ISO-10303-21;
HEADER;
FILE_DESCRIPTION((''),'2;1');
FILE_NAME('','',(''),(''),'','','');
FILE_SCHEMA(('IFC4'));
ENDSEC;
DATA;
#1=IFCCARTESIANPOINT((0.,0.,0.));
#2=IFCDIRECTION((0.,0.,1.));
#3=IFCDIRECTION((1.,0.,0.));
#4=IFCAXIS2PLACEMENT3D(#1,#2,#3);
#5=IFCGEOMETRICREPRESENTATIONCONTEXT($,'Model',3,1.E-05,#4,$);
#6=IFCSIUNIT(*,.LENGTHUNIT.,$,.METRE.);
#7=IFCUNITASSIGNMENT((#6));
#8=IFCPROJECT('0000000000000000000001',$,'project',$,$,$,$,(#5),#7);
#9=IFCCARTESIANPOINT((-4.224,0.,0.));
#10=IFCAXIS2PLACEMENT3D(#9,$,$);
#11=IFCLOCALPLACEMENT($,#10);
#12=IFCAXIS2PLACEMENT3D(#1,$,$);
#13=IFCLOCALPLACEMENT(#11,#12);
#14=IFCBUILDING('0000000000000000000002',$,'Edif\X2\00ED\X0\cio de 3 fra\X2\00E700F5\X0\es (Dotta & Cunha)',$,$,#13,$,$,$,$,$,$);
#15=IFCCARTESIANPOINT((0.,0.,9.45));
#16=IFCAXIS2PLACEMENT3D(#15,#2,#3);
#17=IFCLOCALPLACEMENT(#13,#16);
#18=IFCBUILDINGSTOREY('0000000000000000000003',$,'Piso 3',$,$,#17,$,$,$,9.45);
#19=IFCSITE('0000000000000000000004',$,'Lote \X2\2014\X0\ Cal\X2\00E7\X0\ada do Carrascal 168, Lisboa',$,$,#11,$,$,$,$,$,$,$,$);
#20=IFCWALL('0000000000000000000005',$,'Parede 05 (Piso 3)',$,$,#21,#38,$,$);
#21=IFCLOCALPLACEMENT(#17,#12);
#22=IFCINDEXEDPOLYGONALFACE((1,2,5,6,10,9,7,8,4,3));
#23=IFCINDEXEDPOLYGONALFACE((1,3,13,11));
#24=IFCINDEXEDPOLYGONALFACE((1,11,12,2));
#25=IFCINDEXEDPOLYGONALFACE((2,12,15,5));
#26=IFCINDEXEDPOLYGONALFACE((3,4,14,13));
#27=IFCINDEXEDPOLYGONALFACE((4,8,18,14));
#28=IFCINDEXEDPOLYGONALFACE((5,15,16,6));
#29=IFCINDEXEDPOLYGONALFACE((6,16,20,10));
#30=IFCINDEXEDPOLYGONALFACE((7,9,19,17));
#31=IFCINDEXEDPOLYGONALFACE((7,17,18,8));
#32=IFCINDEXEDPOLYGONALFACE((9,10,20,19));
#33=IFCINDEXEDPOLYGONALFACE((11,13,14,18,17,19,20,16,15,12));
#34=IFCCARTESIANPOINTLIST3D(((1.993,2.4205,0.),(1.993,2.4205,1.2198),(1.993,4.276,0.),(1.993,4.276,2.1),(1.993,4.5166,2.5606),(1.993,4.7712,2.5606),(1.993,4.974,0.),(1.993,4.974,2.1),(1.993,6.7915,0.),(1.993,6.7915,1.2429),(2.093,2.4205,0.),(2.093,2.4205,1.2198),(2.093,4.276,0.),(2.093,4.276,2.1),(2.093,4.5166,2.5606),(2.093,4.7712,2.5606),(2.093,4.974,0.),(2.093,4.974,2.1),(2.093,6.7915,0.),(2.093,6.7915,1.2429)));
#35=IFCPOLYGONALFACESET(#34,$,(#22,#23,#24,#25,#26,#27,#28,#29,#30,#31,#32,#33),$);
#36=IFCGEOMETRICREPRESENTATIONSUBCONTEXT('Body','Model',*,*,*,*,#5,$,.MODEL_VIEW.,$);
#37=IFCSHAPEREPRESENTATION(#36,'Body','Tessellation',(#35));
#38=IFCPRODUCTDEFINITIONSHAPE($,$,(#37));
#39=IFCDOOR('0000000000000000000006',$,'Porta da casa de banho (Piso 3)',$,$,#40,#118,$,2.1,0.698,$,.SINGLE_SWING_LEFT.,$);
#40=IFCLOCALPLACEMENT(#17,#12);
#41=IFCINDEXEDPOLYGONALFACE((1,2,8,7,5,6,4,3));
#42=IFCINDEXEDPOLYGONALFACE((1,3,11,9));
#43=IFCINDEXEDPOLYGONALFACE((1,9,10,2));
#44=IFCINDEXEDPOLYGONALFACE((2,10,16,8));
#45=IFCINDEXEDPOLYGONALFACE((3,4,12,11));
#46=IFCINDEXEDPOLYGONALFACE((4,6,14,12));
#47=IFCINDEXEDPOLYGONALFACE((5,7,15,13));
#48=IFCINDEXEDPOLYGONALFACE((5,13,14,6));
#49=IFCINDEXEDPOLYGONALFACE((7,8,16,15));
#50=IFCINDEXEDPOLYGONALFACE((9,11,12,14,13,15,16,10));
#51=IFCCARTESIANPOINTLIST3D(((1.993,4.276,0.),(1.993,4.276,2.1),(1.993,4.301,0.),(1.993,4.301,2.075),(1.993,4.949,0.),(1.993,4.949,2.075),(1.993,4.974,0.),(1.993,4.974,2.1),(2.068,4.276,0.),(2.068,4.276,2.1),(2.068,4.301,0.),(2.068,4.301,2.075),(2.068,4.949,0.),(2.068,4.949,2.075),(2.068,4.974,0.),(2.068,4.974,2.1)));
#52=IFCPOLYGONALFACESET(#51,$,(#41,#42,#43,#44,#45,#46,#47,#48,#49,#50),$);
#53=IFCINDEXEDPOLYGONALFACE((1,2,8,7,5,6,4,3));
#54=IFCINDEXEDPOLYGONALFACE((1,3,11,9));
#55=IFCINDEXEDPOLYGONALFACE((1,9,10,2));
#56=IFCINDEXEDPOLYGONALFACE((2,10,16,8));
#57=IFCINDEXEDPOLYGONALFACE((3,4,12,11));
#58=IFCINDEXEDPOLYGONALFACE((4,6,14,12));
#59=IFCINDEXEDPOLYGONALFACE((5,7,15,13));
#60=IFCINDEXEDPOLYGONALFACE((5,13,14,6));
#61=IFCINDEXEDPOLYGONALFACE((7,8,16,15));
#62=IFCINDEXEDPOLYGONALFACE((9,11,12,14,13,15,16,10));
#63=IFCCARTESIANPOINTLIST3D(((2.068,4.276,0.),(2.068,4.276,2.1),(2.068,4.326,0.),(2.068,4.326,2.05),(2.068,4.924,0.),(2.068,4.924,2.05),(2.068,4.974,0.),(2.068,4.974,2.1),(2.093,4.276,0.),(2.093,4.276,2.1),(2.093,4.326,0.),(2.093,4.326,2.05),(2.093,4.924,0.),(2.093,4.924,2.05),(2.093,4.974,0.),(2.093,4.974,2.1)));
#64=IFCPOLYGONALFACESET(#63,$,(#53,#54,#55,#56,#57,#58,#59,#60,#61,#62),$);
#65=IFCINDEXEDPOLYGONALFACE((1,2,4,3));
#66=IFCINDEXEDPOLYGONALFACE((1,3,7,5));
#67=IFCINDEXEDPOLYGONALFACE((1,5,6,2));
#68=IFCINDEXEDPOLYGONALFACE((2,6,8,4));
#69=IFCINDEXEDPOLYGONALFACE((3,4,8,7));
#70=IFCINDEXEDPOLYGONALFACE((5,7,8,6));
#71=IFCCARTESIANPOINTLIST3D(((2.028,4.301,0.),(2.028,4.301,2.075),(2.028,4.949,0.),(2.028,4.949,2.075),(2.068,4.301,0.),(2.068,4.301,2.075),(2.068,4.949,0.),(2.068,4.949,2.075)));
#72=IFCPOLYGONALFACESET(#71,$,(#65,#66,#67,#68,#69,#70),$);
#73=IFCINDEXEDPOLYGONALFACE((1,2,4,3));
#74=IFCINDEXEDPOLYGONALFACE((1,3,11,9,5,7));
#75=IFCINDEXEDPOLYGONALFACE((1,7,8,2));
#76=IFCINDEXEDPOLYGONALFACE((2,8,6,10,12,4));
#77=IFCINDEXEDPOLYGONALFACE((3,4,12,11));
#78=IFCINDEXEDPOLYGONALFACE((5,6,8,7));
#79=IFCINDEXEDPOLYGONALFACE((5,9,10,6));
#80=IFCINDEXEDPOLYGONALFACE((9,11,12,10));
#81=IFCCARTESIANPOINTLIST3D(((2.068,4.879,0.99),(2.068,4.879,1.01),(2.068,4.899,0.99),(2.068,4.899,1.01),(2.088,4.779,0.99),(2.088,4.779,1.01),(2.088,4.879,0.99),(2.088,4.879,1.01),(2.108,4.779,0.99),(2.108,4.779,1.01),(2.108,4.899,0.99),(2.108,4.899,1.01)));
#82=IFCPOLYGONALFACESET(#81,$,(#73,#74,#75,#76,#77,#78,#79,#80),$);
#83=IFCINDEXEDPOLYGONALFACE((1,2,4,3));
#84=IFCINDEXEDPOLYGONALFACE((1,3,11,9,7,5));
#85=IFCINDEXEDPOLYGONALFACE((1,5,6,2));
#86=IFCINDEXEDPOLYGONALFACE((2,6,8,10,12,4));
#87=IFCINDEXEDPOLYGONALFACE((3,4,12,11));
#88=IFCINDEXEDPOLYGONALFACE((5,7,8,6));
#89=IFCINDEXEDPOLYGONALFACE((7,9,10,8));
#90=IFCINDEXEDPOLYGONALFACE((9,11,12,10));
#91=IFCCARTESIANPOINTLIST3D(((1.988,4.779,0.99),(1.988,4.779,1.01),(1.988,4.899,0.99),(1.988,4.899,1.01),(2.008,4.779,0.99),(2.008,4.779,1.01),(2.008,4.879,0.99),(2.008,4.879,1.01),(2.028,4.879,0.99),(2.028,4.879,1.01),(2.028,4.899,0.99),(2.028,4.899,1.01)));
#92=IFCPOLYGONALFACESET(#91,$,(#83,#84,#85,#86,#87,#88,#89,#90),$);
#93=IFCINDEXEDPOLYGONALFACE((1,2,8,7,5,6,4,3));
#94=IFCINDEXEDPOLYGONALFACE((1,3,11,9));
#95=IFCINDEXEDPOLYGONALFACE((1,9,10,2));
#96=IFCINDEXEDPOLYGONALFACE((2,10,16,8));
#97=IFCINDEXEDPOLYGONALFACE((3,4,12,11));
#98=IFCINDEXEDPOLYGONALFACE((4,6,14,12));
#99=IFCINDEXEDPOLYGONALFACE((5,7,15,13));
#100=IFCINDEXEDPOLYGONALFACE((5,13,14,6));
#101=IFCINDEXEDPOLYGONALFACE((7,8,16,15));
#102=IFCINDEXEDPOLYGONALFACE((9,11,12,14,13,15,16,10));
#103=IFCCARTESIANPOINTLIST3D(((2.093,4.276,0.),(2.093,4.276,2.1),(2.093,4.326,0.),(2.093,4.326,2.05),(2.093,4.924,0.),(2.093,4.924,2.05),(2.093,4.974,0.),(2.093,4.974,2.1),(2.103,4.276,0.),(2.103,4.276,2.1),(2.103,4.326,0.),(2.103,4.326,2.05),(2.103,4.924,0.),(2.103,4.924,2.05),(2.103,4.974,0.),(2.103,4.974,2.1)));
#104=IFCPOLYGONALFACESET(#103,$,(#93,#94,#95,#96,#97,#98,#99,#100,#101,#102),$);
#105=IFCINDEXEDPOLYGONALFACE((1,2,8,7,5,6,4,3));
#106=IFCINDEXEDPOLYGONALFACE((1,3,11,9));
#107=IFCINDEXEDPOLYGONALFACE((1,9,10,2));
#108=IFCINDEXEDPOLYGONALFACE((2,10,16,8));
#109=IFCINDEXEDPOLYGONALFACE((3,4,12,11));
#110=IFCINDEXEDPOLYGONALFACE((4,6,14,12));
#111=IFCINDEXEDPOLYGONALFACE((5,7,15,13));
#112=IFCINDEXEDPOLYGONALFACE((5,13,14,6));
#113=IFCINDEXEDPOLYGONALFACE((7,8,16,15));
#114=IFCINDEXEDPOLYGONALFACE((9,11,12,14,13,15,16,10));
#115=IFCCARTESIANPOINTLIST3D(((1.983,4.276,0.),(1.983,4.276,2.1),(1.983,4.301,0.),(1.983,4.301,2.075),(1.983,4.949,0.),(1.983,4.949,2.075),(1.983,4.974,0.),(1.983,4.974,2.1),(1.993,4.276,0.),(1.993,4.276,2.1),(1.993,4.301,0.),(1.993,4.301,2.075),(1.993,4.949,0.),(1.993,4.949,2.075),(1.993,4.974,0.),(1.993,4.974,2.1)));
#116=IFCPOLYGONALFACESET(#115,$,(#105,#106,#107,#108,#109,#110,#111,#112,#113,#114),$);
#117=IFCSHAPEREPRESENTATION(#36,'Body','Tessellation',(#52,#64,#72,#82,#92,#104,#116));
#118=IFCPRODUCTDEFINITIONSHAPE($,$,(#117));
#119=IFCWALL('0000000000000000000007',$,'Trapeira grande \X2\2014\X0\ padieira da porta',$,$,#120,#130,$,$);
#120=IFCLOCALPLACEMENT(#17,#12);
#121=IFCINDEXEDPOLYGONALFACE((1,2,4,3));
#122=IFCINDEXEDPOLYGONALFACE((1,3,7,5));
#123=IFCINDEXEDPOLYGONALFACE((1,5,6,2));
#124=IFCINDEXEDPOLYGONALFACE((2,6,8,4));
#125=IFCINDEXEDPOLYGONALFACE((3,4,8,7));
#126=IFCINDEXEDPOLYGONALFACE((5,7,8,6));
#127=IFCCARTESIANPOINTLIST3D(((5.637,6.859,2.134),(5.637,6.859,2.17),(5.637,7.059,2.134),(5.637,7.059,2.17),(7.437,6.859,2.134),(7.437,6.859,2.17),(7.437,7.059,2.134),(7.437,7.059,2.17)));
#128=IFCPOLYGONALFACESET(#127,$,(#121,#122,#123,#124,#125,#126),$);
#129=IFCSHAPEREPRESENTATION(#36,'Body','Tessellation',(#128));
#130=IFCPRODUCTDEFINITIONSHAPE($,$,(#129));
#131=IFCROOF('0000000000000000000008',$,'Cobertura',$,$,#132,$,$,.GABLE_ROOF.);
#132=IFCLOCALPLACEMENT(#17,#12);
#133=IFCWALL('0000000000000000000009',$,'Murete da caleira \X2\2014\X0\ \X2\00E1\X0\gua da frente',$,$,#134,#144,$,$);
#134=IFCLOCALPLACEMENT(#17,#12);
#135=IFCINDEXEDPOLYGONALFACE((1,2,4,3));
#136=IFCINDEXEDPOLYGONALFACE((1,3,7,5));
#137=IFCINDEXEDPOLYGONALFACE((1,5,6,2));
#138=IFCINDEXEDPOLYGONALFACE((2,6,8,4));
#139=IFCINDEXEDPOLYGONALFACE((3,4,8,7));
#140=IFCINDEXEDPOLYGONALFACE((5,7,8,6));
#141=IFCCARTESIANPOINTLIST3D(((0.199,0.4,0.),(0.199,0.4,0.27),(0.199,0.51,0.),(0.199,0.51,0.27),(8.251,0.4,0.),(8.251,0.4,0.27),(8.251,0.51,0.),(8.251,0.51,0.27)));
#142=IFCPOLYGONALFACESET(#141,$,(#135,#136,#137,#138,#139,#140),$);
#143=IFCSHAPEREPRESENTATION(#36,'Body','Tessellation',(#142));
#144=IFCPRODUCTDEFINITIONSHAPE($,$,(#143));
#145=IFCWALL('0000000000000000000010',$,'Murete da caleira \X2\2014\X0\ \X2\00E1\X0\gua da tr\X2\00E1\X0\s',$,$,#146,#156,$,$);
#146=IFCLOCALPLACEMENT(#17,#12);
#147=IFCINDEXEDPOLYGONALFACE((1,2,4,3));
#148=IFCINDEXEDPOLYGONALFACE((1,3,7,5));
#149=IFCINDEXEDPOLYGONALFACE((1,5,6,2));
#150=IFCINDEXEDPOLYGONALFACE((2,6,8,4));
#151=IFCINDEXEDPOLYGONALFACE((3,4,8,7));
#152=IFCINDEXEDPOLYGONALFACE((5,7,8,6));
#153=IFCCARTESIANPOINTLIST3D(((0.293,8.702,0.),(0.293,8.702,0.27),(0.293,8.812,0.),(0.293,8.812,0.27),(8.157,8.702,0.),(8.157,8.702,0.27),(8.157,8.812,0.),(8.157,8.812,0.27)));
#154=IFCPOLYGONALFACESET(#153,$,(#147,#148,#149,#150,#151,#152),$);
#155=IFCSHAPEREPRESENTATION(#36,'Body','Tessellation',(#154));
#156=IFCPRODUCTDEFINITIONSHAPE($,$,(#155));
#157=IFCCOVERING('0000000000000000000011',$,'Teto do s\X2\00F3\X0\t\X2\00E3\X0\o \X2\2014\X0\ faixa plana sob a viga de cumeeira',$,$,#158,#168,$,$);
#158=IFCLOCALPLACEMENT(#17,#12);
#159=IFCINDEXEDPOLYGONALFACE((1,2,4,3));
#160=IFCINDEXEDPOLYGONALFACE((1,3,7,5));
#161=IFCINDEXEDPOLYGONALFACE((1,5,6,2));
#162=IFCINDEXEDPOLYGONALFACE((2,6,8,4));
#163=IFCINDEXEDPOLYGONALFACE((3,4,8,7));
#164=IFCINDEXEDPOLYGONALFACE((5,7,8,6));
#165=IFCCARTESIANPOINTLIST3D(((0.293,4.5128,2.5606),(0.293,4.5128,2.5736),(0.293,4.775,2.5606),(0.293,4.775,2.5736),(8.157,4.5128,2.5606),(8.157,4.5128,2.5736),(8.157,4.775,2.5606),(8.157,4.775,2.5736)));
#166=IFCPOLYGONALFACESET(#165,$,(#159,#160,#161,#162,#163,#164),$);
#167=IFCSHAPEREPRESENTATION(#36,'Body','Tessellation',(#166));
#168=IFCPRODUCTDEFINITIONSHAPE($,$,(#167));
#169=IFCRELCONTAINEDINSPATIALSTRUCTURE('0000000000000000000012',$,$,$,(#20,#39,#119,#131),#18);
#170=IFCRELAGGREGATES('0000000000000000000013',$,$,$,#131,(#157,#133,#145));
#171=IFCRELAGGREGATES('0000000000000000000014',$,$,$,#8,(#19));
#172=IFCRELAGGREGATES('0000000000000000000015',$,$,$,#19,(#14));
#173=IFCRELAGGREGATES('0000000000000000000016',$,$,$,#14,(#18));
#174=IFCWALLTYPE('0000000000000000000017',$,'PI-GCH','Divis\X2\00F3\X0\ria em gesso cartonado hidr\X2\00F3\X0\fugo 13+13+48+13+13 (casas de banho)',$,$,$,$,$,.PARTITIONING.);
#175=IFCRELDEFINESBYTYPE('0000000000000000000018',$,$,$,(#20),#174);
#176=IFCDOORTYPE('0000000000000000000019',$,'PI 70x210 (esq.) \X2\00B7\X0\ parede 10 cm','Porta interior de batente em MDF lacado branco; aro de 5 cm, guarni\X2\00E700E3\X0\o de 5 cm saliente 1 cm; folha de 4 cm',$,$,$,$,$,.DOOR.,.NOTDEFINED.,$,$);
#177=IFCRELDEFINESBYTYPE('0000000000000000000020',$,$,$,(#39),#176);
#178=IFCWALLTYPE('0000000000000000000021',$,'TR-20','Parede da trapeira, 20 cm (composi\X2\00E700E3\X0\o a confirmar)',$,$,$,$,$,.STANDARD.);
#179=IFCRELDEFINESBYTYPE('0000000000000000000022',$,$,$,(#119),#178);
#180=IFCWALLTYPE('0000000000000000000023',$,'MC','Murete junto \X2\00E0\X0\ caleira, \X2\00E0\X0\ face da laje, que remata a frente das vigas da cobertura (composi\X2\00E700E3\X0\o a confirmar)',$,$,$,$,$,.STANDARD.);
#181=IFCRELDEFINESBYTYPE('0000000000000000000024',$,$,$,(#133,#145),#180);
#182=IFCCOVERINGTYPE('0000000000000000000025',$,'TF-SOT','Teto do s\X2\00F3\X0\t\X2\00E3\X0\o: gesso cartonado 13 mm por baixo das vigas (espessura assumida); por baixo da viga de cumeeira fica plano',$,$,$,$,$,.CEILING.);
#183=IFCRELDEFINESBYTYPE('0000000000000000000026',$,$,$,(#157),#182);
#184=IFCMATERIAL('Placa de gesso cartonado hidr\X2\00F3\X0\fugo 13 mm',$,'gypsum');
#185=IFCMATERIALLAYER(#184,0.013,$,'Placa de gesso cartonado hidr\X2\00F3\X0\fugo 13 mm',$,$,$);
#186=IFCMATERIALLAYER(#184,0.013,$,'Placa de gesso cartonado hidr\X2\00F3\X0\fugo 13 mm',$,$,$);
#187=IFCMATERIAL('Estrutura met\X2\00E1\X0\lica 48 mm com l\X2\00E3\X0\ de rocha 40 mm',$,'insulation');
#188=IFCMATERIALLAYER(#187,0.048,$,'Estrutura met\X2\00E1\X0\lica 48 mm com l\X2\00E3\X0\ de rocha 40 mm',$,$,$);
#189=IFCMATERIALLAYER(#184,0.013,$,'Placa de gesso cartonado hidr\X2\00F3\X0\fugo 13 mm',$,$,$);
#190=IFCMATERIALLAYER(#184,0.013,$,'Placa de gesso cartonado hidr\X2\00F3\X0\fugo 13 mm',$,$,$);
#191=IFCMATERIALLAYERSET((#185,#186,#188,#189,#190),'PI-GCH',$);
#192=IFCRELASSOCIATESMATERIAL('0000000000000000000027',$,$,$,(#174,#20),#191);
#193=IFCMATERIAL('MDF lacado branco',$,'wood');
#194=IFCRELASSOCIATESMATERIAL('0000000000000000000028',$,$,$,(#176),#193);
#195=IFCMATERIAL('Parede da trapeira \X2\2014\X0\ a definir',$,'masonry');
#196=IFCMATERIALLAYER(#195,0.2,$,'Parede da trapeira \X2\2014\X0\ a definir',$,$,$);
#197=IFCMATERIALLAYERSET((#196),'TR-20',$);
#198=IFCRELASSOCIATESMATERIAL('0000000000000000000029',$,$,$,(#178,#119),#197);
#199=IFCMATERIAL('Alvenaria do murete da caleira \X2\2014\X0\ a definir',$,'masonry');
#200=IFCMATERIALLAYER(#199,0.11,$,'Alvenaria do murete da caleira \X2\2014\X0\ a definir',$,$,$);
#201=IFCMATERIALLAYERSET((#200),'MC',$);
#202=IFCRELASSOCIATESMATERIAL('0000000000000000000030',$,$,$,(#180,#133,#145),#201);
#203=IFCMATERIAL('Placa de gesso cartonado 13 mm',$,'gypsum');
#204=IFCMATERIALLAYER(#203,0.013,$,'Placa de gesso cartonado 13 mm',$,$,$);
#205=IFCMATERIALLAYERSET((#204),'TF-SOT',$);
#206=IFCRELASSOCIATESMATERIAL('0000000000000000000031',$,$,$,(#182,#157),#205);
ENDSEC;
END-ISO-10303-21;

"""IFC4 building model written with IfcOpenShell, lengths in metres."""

from ifc_helpers import new_model, si_unit, frame, origin, origin_with_axes, place, context, subcontext, project, spatial, line, indexed_curve, outline, extrude, clip, halfspace, source, transform, mapped, material, layer, layer_set, layer_usage, type_object, type_shapes, element, fill, aggregate, save


model = new_model("IFC4")

# Units and contexts
model_context = context("Model", 3, precision=1e-05, world=origin_with_axes())
body_context = subcontext(model_context, "Body", "Model", "MODEL_VIEW")
ifc_project = project(units=[si_unit("LENGTHUNIT", "METRE")], contexts=[model_context])

# Site, building, storey
site_placement = place(None, frame((-4.224, 0.0, 0.0)))
site = spatial("IfcSite", under=ifc_project, at=site_placement, Name="Lote — Calçada do Carrascal 168, Lisboa")
building_placement = place(site_placement, origin())
building = spatial("IfcBuilding", under=site, at=building_placement, Name="Edifício de 3 frações (Dotta & Cunha)")
storey_placement = place(building_placement, frame((0.0, 0.0, 9.45), z_axis=(0.0, 0.0, 1.0), x_axis=(1.0, 0.0, 0.0)))
storey = spatial("IfcBuildingStorey", under=building, at=storey_placement, Name="Piso 3", Elevation=9.45)

# Wall, opening, door
ifc_material_1 = material(Name="Placa de gesso cartonado 13 mm", Category="gypsum")
ifc_material_2 = material(Name="Estrutura metálica 48 mm com lã de rocha 40 mm", Category="insulation")
ifc_material_3 = material(Name="MDF lacado branco", Category="wood")
ifc_material_4 = material(Name="Placa de gesso cartonado hidrófugo 13 mm", Category="gypsum")
ifc_layer_1 = layer(ifc_material_4, 0.013, Name="Placa de gesso cartonado hidrófugo 13 mm")
ifc_layer_2 = layer(ifc_material_4, 0.013, Name="Placa de gesso cartonado hidrófugo 13 mm")
ifc_layer_3 = layer(ifc_material_2, 0.048, Name="Estrutura metálica 48 mm com lã de rocha 40 mm")
ifc_layer_4 = layer(ifc_material_4, 0.013, Name="Placa de gesso cartonado hidrófugo 13 mm")
ifc_layer_5 = layer(ifc_material_4, 0.013, Name="Placa de gesso cartonado hidrófugo 13 mm")
ifc_layer_set_1 = layer_set([ifc_layer_1, ifc_layer_2, ifc_layer_3, ifc_layer_4, ifc_layer_5], Name="PI-GCH")
ifc_layer_usage_1 = layer_usage(ifc_layer_set_1, "AXIS2", "POSITIVE", 0.0)
wall_type_1 = type_object("IfcWallType", Name="PI-GCH", Description="Divisória em gesso cartonado hidrófugo 13+13+48+13+13 (casas de banho)", PredefinedType="PARTITIONING", material=ifc_layer_set_1)
wall_1_placement = place(storey_placement, origin_with_axes())
wall_1 = element("IfcWall", 1, at=wall_1_placement, inside=storey, type_object=wall_type_1, material=ifc_layer_usage_1, Name="Parede 05 (Piso 3)", context=body_context, shape_type="Clipping", body=[
    clip(clip(extrude(outline(indexed_curve([(2.093, 2.4205), (2.093, 6.7915), (1.993, 6.7915), (1.993, 2.4205)], segments=[line(1, 2, 3, 4, 1)])), origin_with_axes(), (0.0, 0.0, 1.0), 2.5606), halfspace(frame((0.0, -4.1406, -2.9773), z_axis=(0.0, -0.538875, 0.842386), x_axis=(1.0, 0.0, 0.0)), False)), halfspace(frame((0.0, 6.9196, 1.1594), z_axis=(0.0, 0.546292, 0.837595), x_axis=(1.0, 0.0, 0.0)), False)),
])
opening_1_placement = place(wall_1_placement, origin_with_axes())
opening_1 = element("IfcOpeningElement", 2, at=opening_1_placement, cuts=wall_1, context=body_context, shape_type="SweptSolid", body=[
    extrude(outline(indexed_curve([(2.095, 4.276), (2.095, 4.974), (1.991, 4.974), (1.991, 4.276)], segments=[line(1, 2, 3, 4, 1)])), origin_with_axes(), (0.0, 0.0, 1.0), 2.1),
])
door_type_1 = type_object("IfcDoorType", Name="PI 70x210 (esq.) · parede 10 cm", Description="Porta interior de batente em MDF lacado branco; aro de 5 cm, guarnição de 5 cm saliente 1 cm; folha de 4 cm", OperationType="NOTDEFINED", PredefinedType="DOOR", material=ifc_material_3)
shared_shape_1 = source(origin_with_axes(), body_context, "Body", "SweptSolid", [
    extrude(outline(indexed_curve([(0.0, 0.0), (0.0, 2.1), (0.698, 2.1), (0.698, 0.0), (0.673, 0.0), (0.673, 2.075), (0.025, 2.075), (0.025, 0.0)], segments=[line(1, 2, 3, 4, 5, 6, 7, 8, 1)])), frame((0.0, 0.025, 0.0), z_axis=(0.0, -1.0, 0.0), x_axis=(1.0, 0.0, 0.0)), (0.0, 0.0, -1.0), 0.075),
    extrude(outline(indexed_curve([(0.0, 0.0), (0.0, 2.1), (0.698, 2.1), (0.698, 0.0), (0.648, 0.0), (0.648, 2.05), (0.05, 2.05), (0.05, 0.0)], segments=[line(1, 2, 3, 4, 5, 6, 7, 8, 1)])), frame((0.0, 0.0, 0.0), z_axis=(0.0, -1.0, 0.0), x_axis=(1.0, 0.0, 0.0)), (0.0, 0.0, -1.0), 0.025),
    extrude(outline(indexed_curve([(0.0, 0.0), (0.648, 0.0), (0.648, 0.04), (0.0, 0.04)], segments=[line(1, 2, 3, 4, 1)])), frame((0.025, 0.025, 0.0), z_axis=(0.0, 0.0, 1.0), x_axis=(1.0, 0.0, 0.0)), (0.0, 0.0, 1.0), 2.075),
    extrude(outline(indexed_curve([(0.0, 0.0), (0.0, -0.04), (-0.12, -0.04), (-0.12, -0.02), (-0.02, -0.02), (-0.02, 0.0)], segments=[line(1, 2, 3, 4, 5, 6, 1)])), frame((0.623, 0.025, 0.99), z_axis=(0.0, 0.0, 1.0), x_axis=(1.0, 0.0, 0.0)), (0.0, 0.0, 1.0), 0.02),
    extrude(outline(indexed_curve([(0.0, 0.0), (0.0, 0.04), (-0.12, 0.04), (-0.12, 0.02), (-0.02, 0.02), (-0.02, 0.0)], segments=[line(1, 2, 3, 4, 5, 6, 1)])), frame((0.623, 0.065, 0.99), z_axis=(0.0, 0.0, 1.0), x_axis=(1.0, 0.0, 0.0)), (0.0, 0.0, 1.0), 0.02),
    extrude(outline(indexed_curve([(0.0, 0.0), (0.0, 2.1), (0.698, 2.1), (0.698, 0.0), (0.648, 0.0), (0.648, 2.05), (0.05, 2.05), (0.05, 0.0)], segments=[line(1, 2, 3, 4, 5, 6, 7, 8, 1)])), frame((0.0, -0.01, 0.0), z_axis=(0.0, -1.0, 0.0), x_axis=(1.0, 0.0, 0.0)), (0.0, 0.0, -1.0), 0.01),
    extrude(outline(indexed_curve([(0.0, 0.0), (0.0, 2.1), (0.698, 2.1), (0.698, 0.0), (0.673, 0.0), (0.673, 2.075), (0.025, 2.075), (0.025, 0.0)], segments=[line(1, 2, 3, 4, 5, 6, 7, 8, 1)])), frame((0.0, 0.1, 0.0), z_axis=(0.0, -1.0, 0.0), x_axis=(1.0, 0.0, 0.0)), (0.0, 0.0, -1.0), 0.01),
])
type_shapes(door_type_1, [shared_shape_1])
door_1_placement = place(storey_placement, frame((2.093, 4.276, 0.0), z_axis=(0.0, 0.0, 1.0), x_axis=(0.0, 1.0, 0.0)))
door_1 = element("IfcDoor", 3, at=door_1_placement, inside=storey, type_object=door_type_1, Name="Porta da casa de banho (Piso 3)", OperationType="SINGLE_SWING_LEFT", OverallHeight=2.1, OverallWidth=0.698, context=body_context, shape_type="MappedRepresentation", body=[
    mapped(shared_shape_1, transform((0.0, 0.0, 0.0), x_axis=(1.0, 0.0, 0.0), y_axis=(0.0, 1.0, 0.0), z_axis=(0.0, 0.0, 1.0), scale=1.0)),
])
fill(opening_1, door_1)

# Wall
ifc_material_5 = material(Name="Parede da trapeira — a definir", Category="masonry")
ifc_layer_6 = layer(ifc_material_5, 0.2, Name="Parede da trapeira — a definir")
ifc_layer_set_2 = layer_set([ifc_layer_6], Name="TR-20")
ifc_layer_usage_2 = layer_usage(ifc_layer_set_2, "AXIS2", "POSITIVE", 0.0)
wall_type_2 = type_object("IfcWallType", Name="TR-20", Description="Parede da trapeira, 20 cm (composição a confirmar)", PredefinedType="STANDARD", material=ifc_layer_set_2)
wall_2_placement = place(storey_placement, frame((0.0, 0.0, 2.134), z_axis=(0.0, 0.0, 1.0), x_axis=(1.0, 0.0, 0.0)))
element("IfcWall", 4, at=wall_2_placement, inside=storey, type_object=wall_type_2, material=ifc_layer_usage_2, Name="Trapeira grande — padieira da porta", context=body_context, shape_type="SweptSolid", body=[
    extrude(outline(indexed_curve([(7.437, 6.859), (7.437, 7.059), (5.637, 7.059), (5.637, 6.859)], segments=[line(1, 2, 3, 4, 1)])), origin_with_axes(), (0.0, 0.0, 1.0), 0.036),
])

# Roof, walls, covering
roof_placement = place(storey_placement, frame((0.0, 0.0, -9.45), z_axis=(0.0, 0.0, 1.0), x_axis=(1.0, 0.0, 0.0)))
roof = element("IfcRoof", 5, at=roof_placement, inside=storey, Name="Cobertura", PredefinedType="GABLE_ROOF")
ifc_material_6 = material(Name="Alvenaria do murete da caleira — a definir", Category="masonry")
ifc_layer_7 = layer(ifc_material_6, 0.11, Name="Alvenaria do murete da caleira — a definir")
ifc_layer_set_3 = layer_set([ifc_layer_7], Name="MC")
ifc_layer_usage_3 = layer_usage(ifc_layer_set_3, "AXIS2", "POSITIVE", 0.0)
wall_type_3 = type_object("IfcWallType", Name="MC", Description="Murete junto à caleira, à face da laje, que remata a frente das vigas da cobertura (composição a confirmar)", PredefinedType="STANDARD", material=ifc_layer_set_3)
wall_3_placement = place(roof_placement, frame((0.0, 0.0, 9.45), z_axis=(0.0, 0.0, 1.0), x_axis=(1.0, 0.0, 0.0)))
wall_3 = element("IfcWall", 6, at=wall_3_placement, type_object=wall_type_3, material=ifc_layer_usage_3, Name="Murete da caleira — água da frente", context=body_context, shape_type="SweptSolid", body=[
    extrude(outline(indexed_curve([(8.251, 0.4), (8.251, 0.51), (0.199, 0.51), (0.199, 0.4)], segments=[line(1, 2, 3, 4, 1)])), origin_with_axes(), (0.0, 0.0, 1.0), 0.27),
])
ifc_layer_usage_4 = layer_usage(ifc_layer_set_3, "AXIS2", "POSITIVE", 0.0)
wall_4_placement = place(roof_placement, frame((0.0, 0.0, 9.45), z_axis=(0.0, 0.0, 1.0), x_axis=(1.0, 0.0, 0.0)))
wall_4 = element("IfcWall", 7, at=wall_4_placement, type_object=wall_type_3, material=ifc_layer_usage_4, Name="Murete da caleira — água da trás", context=body_context, shape_type="SweptSolid", body=[
    extrude(outline(indexed_curve([(8.157, 8.702), (8.157, 8.812), (0.293, 8.812), (0.293, 8.702)], segments=[line(1, 2, 3, 4, 1)])), origin_with_axes(), (0.0, 0.0, 1.0), 0.27),
])
ifc_layer_8 = layer(ifc_material_1, 0.013, Name="Placa de gesso cartonado 13 mm")
ifc_layer_set_4 = layer_set([ifc_layer_8], Name="TF-SOT")
ifc_layer_usage_5 = layer_usage(ifc_layer_set_4, "AXIS3", "POSITIVE", 0.0)
covering_type = type_object("IfcCoveringType", Name="TF-SOT", Description="Teto do sótão: gesso cartonado 13 mm por baixo das vigas (espessura assumida); por baixo da viga de cumeeira fica plano", PredefinedType="CEILING", material=ifc_layer_set_4)
covering_1_placement = place(roof_placement, frame((0.0, 0.0, 12.0106), z_axis=(0.0, 0.0, 1.0), x_axis=(1.0, 0.0, 0.0)))
covering_1 = element("IfcCovering", 8, at=covering_1_placement, type_object=covering_type, material=ifc_layer_usage_5, Name="Teto do sótão — faixa plana sob a viga de cumeeira", context=body_context, shape_type="SweptSolid", body=[
    extrude(outline(indexed_curve([(8.157, 4.5128), (0.293, 4.5128), (0.293, 4.775), (8.157, 4.775)], segments=[line(1, 2, 3, 4, 1)])), origin_with_axes(), (0.0, 0.0, 1.0), 0.013),
])
aggregate(roof, [covering_1, wall_3, wall_4])

save(model, "model.ifc")
